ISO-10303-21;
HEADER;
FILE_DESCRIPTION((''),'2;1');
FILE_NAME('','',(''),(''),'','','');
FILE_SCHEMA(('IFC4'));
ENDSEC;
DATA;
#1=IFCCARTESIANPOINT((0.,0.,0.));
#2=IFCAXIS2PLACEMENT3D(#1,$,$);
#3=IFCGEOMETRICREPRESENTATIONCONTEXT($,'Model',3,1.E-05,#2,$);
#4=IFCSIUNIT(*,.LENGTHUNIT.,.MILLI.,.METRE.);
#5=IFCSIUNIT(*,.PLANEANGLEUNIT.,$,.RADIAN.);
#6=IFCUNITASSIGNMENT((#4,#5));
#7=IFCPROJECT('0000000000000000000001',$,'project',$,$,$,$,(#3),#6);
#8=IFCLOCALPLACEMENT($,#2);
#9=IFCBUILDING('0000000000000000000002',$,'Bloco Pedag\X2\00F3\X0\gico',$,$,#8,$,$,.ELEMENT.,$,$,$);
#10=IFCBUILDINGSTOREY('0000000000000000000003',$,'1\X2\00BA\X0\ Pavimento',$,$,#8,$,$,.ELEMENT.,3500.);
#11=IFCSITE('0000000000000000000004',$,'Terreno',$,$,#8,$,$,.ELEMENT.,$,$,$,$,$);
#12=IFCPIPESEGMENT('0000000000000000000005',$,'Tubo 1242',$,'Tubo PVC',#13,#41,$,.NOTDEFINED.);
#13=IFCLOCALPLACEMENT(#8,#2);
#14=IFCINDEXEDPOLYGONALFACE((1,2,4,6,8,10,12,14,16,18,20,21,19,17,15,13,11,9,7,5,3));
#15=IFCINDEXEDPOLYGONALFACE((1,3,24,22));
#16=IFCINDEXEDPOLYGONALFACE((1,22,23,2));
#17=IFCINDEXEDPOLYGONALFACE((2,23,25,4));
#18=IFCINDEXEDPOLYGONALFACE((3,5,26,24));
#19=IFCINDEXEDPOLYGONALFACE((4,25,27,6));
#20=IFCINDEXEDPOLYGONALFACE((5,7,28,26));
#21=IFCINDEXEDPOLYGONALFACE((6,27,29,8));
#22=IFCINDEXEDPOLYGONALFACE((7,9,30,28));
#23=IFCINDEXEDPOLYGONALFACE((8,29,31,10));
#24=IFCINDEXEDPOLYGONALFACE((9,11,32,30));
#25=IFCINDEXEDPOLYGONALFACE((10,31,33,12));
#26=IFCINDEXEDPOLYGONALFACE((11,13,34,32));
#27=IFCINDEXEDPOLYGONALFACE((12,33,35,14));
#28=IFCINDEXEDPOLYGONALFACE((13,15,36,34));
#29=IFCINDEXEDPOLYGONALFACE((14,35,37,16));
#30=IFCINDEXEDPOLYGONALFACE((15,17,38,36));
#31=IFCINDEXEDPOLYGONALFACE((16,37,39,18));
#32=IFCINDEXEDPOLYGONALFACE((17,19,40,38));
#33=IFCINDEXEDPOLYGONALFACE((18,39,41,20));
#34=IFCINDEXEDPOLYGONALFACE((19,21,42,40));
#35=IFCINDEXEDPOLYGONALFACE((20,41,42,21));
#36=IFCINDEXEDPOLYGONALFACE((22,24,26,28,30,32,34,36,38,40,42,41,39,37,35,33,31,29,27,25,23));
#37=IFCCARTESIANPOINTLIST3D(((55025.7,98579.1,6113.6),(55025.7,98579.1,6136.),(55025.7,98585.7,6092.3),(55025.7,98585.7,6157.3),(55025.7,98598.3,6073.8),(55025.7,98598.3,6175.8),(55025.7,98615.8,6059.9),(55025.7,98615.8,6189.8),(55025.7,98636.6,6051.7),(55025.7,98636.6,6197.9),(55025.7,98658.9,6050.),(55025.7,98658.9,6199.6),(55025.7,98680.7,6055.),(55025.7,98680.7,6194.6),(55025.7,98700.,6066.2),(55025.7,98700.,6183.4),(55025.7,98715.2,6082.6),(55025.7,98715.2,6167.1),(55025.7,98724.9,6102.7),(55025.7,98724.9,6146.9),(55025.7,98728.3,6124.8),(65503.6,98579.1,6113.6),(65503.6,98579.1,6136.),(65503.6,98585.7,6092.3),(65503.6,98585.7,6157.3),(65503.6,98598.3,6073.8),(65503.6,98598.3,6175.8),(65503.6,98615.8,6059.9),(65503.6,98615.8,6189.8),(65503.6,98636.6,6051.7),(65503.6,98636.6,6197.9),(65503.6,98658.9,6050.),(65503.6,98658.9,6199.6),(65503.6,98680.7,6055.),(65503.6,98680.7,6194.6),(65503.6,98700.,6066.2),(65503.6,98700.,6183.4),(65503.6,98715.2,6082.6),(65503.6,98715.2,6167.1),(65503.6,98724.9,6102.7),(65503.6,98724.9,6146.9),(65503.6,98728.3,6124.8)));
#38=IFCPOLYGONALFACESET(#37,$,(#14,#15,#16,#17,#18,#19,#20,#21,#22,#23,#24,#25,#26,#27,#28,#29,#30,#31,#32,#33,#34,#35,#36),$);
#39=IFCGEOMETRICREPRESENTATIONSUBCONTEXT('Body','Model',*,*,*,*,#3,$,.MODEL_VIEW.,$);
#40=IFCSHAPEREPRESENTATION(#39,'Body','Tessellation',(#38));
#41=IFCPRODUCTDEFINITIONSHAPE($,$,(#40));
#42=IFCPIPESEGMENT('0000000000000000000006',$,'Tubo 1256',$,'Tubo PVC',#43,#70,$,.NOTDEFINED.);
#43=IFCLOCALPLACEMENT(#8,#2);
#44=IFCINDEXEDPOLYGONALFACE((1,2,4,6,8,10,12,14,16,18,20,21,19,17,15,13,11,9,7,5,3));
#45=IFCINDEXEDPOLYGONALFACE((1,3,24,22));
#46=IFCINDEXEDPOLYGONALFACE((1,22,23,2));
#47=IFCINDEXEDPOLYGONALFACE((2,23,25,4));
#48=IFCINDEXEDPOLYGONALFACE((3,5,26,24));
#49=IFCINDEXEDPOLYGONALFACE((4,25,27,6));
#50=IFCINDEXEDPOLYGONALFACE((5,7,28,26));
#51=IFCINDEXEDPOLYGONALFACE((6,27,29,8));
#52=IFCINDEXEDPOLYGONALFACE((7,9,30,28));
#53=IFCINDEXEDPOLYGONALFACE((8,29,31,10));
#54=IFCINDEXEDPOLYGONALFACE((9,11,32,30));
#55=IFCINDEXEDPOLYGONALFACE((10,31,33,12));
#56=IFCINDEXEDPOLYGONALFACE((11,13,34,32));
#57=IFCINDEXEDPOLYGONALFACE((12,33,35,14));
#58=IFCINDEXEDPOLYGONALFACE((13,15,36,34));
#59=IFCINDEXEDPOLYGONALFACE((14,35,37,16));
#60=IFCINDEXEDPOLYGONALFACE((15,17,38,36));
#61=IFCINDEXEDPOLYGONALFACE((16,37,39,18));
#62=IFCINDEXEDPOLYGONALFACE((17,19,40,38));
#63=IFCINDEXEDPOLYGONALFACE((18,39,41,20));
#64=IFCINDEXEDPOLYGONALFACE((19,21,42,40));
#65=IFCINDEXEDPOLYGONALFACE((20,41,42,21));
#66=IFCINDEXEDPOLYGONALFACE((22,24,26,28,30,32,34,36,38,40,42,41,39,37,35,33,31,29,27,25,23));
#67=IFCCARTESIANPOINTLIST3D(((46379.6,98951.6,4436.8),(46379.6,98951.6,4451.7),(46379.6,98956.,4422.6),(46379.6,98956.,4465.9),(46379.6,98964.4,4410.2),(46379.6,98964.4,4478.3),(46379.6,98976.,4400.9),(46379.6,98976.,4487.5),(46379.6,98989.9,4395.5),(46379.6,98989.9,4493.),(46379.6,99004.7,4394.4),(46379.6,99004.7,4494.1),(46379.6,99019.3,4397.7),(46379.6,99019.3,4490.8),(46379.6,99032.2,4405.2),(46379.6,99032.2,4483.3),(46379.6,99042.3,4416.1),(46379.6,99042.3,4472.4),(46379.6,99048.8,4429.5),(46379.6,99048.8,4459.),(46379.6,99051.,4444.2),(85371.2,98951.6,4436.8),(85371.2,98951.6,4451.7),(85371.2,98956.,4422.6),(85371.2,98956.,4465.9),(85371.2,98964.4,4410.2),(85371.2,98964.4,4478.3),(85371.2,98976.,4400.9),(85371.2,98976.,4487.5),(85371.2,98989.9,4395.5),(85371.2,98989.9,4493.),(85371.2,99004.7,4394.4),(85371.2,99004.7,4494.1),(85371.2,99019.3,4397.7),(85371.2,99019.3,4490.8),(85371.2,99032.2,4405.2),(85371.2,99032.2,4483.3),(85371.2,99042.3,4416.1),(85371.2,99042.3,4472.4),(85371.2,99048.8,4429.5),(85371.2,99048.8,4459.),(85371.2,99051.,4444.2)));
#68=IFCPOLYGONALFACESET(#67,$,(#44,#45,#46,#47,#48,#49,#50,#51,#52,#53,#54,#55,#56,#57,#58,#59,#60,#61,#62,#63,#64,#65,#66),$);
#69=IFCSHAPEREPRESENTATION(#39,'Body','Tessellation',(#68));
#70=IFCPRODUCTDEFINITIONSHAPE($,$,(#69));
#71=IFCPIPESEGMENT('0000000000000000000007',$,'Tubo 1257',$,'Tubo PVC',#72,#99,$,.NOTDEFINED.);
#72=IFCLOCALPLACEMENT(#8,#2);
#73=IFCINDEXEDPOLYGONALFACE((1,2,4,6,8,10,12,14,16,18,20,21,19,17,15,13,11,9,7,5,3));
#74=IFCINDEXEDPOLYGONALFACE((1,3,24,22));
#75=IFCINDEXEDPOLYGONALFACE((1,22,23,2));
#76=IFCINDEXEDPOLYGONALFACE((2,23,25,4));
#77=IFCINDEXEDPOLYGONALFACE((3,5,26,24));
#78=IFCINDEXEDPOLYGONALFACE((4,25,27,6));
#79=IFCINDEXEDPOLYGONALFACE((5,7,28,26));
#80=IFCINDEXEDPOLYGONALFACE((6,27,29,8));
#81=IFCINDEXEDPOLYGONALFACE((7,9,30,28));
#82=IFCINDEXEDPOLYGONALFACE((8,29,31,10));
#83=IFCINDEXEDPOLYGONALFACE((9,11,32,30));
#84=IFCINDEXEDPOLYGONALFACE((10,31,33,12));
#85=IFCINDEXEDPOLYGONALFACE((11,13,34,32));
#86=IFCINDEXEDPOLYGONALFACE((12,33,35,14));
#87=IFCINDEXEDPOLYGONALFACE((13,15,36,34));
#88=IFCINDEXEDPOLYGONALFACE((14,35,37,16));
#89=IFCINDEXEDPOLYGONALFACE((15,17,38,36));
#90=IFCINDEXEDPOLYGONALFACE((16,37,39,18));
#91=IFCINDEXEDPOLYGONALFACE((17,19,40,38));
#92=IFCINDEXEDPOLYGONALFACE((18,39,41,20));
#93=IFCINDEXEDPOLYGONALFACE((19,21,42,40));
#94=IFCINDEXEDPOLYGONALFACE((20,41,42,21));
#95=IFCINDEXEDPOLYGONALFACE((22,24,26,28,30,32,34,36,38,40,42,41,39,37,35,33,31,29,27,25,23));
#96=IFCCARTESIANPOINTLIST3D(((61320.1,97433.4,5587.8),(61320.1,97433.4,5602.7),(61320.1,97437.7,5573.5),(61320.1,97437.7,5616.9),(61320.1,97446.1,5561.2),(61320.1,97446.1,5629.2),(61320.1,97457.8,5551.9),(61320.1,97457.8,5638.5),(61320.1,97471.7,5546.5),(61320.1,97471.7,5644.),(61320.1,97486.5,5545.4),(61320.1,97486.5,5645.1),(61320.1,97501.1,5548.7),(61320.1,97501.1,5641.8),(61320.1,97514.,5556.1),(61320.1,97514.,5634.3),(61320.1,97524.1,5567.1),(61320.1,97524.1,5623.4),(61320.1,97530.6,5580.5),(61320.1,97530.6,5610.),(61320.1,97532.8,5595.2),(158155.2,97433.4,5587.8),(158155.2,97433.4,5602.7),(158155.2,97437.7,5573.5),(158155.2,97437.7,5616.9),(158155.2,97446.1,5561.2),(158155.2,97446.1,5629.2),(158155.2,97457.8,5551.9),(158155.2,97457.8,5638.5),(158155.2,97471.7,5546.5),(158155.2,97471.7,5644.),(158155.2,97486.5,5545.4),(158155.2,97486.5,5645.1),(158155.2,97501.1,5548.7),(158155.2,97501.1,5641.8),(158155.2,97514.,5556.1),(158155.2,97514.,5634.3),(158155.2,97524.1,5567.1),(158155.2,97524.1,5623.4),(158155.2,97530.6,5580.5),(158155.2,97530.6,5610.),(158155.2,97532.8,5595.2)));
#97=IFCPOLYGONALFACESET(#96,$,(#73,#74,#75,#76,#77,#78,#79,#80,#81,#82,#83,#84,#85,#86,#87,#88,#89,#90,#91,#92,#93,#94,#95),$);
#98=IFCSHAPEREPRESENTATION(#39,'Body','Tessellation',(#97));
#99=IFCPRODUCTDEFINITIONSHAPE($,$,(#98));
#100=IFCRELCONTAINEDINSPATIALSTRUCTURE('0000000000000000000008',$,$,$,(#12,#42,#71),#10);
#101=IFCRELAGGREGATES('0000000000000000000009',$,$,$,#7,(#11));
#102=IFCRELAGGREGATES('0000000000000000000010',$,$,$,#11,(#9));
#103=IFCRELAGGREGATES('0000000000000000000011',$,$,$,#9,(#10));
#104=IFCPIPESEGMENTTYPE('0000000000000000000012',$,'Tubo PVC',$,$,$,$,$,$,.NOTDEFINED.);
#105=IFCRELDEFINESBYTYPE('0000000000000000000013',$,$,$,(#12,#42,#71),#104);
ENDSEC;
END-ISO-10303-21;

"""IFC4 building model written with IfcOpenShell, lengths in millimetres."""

from ifc_helpers import new_model, si_unit, frame, origin, origin_2d, place, context, subcontext, project, spatial, circle, extrude, type_object, element, save


model = new_model("IFC4")

# Units and contexts
model_context = context("Model", 3, precision=1e-05, world=origin())
body_context = subcontext(model_context, "Body", "Model", "MODEL_VIEW")
ifc_project = project(units=[si_unit("LENGTHUNIT", "METRE", prefix="MILLI"), si_unit("PLANEANGLEUNIT", "RADIAN")], contexts=[model_context])

# Site, building, storey
placement = place(None, origin())
site = spatial("IfcSite", under=ifc_project, at=placement, Name="Terreno", CompositionType="ELEMENT")
building = spatial("IfcBuilding", under=site, at=placement, Name="Bloco Pedagógico", CompositionType="ELEMENT")
storey = spatial("IfcBuildingStorey", under=building, at=placement, Name="1º Pavimento", CompositionType="ELEMENT", Elevation=3500.0)

# Pipe segments
pipe_segment_type = type_object("IfcPipeSegmentType", Name="Tubo PVC", PredefinedType="NOTDEFINED")
pipe_segment_1_placement = place(None, frame((55025.7, 98653.3, 6124.8), z_axis=(1.0, 0.0, 0.0), x_axis=(0.0, 1.0, 0.0)))
element("IfcPipeSegment", 1, at=pipe_segment_1_placement, inside=storey, type_object=pipe_segment_type, Name="Tubo 1242", ObjectType="Tubo PVC", PredefinedType="NOTDEFINED", context=body_context, shape_type="SweptSolid", body=[
    extrude(circle(Radius=75.0, at=origin_2d()), None, (0.0, 0.0, 1.0), 10478.0),
])
pipe_segment_2_placement = place(None, frame((46379.6, 99001.0, 4444.2), z_axis=(1.0, 0.0, 0.0), x_axis=(0.0, 1.0, 0.0)))
element("IfcPipeSegment", 2, at=pipe_segment_2_placement, inside=storey, type_object=pipe_segment_type, Name="Tubo 1256", ObjectType="Tubo PVC", PredefinedType="NOTDEFINED", context=body_context, shape_type="SweptSolid", body=[
    extrude(circle(Radius=50.0, at=origin_2d()), None, (0.0, 0.0, 1.0), 38991.6),
])
pipe_segment_3_placement = place(None, frame((61320.1, 97482.8, 5595.2), z_axis=(1.0, 0.0, 0.0), x_axis=(0.0, 1.0, 0.0)))
element("IfcPipeSegment", 3, at=pipe_segment_3_placement, inside=storey, type_object=pipe_segment_type, Name="Tubo 1257", ObjectType="Tubo PVC", PredefinedType="NOTDEFINED", context=body_context, shape_type="SweptSolid", body=[
    extrude(circle(Radius=50.0, at=origin_2d()), None, (0.0, 0.0, 1.0), 96835.2),
])

save(model, "model.ifc")
